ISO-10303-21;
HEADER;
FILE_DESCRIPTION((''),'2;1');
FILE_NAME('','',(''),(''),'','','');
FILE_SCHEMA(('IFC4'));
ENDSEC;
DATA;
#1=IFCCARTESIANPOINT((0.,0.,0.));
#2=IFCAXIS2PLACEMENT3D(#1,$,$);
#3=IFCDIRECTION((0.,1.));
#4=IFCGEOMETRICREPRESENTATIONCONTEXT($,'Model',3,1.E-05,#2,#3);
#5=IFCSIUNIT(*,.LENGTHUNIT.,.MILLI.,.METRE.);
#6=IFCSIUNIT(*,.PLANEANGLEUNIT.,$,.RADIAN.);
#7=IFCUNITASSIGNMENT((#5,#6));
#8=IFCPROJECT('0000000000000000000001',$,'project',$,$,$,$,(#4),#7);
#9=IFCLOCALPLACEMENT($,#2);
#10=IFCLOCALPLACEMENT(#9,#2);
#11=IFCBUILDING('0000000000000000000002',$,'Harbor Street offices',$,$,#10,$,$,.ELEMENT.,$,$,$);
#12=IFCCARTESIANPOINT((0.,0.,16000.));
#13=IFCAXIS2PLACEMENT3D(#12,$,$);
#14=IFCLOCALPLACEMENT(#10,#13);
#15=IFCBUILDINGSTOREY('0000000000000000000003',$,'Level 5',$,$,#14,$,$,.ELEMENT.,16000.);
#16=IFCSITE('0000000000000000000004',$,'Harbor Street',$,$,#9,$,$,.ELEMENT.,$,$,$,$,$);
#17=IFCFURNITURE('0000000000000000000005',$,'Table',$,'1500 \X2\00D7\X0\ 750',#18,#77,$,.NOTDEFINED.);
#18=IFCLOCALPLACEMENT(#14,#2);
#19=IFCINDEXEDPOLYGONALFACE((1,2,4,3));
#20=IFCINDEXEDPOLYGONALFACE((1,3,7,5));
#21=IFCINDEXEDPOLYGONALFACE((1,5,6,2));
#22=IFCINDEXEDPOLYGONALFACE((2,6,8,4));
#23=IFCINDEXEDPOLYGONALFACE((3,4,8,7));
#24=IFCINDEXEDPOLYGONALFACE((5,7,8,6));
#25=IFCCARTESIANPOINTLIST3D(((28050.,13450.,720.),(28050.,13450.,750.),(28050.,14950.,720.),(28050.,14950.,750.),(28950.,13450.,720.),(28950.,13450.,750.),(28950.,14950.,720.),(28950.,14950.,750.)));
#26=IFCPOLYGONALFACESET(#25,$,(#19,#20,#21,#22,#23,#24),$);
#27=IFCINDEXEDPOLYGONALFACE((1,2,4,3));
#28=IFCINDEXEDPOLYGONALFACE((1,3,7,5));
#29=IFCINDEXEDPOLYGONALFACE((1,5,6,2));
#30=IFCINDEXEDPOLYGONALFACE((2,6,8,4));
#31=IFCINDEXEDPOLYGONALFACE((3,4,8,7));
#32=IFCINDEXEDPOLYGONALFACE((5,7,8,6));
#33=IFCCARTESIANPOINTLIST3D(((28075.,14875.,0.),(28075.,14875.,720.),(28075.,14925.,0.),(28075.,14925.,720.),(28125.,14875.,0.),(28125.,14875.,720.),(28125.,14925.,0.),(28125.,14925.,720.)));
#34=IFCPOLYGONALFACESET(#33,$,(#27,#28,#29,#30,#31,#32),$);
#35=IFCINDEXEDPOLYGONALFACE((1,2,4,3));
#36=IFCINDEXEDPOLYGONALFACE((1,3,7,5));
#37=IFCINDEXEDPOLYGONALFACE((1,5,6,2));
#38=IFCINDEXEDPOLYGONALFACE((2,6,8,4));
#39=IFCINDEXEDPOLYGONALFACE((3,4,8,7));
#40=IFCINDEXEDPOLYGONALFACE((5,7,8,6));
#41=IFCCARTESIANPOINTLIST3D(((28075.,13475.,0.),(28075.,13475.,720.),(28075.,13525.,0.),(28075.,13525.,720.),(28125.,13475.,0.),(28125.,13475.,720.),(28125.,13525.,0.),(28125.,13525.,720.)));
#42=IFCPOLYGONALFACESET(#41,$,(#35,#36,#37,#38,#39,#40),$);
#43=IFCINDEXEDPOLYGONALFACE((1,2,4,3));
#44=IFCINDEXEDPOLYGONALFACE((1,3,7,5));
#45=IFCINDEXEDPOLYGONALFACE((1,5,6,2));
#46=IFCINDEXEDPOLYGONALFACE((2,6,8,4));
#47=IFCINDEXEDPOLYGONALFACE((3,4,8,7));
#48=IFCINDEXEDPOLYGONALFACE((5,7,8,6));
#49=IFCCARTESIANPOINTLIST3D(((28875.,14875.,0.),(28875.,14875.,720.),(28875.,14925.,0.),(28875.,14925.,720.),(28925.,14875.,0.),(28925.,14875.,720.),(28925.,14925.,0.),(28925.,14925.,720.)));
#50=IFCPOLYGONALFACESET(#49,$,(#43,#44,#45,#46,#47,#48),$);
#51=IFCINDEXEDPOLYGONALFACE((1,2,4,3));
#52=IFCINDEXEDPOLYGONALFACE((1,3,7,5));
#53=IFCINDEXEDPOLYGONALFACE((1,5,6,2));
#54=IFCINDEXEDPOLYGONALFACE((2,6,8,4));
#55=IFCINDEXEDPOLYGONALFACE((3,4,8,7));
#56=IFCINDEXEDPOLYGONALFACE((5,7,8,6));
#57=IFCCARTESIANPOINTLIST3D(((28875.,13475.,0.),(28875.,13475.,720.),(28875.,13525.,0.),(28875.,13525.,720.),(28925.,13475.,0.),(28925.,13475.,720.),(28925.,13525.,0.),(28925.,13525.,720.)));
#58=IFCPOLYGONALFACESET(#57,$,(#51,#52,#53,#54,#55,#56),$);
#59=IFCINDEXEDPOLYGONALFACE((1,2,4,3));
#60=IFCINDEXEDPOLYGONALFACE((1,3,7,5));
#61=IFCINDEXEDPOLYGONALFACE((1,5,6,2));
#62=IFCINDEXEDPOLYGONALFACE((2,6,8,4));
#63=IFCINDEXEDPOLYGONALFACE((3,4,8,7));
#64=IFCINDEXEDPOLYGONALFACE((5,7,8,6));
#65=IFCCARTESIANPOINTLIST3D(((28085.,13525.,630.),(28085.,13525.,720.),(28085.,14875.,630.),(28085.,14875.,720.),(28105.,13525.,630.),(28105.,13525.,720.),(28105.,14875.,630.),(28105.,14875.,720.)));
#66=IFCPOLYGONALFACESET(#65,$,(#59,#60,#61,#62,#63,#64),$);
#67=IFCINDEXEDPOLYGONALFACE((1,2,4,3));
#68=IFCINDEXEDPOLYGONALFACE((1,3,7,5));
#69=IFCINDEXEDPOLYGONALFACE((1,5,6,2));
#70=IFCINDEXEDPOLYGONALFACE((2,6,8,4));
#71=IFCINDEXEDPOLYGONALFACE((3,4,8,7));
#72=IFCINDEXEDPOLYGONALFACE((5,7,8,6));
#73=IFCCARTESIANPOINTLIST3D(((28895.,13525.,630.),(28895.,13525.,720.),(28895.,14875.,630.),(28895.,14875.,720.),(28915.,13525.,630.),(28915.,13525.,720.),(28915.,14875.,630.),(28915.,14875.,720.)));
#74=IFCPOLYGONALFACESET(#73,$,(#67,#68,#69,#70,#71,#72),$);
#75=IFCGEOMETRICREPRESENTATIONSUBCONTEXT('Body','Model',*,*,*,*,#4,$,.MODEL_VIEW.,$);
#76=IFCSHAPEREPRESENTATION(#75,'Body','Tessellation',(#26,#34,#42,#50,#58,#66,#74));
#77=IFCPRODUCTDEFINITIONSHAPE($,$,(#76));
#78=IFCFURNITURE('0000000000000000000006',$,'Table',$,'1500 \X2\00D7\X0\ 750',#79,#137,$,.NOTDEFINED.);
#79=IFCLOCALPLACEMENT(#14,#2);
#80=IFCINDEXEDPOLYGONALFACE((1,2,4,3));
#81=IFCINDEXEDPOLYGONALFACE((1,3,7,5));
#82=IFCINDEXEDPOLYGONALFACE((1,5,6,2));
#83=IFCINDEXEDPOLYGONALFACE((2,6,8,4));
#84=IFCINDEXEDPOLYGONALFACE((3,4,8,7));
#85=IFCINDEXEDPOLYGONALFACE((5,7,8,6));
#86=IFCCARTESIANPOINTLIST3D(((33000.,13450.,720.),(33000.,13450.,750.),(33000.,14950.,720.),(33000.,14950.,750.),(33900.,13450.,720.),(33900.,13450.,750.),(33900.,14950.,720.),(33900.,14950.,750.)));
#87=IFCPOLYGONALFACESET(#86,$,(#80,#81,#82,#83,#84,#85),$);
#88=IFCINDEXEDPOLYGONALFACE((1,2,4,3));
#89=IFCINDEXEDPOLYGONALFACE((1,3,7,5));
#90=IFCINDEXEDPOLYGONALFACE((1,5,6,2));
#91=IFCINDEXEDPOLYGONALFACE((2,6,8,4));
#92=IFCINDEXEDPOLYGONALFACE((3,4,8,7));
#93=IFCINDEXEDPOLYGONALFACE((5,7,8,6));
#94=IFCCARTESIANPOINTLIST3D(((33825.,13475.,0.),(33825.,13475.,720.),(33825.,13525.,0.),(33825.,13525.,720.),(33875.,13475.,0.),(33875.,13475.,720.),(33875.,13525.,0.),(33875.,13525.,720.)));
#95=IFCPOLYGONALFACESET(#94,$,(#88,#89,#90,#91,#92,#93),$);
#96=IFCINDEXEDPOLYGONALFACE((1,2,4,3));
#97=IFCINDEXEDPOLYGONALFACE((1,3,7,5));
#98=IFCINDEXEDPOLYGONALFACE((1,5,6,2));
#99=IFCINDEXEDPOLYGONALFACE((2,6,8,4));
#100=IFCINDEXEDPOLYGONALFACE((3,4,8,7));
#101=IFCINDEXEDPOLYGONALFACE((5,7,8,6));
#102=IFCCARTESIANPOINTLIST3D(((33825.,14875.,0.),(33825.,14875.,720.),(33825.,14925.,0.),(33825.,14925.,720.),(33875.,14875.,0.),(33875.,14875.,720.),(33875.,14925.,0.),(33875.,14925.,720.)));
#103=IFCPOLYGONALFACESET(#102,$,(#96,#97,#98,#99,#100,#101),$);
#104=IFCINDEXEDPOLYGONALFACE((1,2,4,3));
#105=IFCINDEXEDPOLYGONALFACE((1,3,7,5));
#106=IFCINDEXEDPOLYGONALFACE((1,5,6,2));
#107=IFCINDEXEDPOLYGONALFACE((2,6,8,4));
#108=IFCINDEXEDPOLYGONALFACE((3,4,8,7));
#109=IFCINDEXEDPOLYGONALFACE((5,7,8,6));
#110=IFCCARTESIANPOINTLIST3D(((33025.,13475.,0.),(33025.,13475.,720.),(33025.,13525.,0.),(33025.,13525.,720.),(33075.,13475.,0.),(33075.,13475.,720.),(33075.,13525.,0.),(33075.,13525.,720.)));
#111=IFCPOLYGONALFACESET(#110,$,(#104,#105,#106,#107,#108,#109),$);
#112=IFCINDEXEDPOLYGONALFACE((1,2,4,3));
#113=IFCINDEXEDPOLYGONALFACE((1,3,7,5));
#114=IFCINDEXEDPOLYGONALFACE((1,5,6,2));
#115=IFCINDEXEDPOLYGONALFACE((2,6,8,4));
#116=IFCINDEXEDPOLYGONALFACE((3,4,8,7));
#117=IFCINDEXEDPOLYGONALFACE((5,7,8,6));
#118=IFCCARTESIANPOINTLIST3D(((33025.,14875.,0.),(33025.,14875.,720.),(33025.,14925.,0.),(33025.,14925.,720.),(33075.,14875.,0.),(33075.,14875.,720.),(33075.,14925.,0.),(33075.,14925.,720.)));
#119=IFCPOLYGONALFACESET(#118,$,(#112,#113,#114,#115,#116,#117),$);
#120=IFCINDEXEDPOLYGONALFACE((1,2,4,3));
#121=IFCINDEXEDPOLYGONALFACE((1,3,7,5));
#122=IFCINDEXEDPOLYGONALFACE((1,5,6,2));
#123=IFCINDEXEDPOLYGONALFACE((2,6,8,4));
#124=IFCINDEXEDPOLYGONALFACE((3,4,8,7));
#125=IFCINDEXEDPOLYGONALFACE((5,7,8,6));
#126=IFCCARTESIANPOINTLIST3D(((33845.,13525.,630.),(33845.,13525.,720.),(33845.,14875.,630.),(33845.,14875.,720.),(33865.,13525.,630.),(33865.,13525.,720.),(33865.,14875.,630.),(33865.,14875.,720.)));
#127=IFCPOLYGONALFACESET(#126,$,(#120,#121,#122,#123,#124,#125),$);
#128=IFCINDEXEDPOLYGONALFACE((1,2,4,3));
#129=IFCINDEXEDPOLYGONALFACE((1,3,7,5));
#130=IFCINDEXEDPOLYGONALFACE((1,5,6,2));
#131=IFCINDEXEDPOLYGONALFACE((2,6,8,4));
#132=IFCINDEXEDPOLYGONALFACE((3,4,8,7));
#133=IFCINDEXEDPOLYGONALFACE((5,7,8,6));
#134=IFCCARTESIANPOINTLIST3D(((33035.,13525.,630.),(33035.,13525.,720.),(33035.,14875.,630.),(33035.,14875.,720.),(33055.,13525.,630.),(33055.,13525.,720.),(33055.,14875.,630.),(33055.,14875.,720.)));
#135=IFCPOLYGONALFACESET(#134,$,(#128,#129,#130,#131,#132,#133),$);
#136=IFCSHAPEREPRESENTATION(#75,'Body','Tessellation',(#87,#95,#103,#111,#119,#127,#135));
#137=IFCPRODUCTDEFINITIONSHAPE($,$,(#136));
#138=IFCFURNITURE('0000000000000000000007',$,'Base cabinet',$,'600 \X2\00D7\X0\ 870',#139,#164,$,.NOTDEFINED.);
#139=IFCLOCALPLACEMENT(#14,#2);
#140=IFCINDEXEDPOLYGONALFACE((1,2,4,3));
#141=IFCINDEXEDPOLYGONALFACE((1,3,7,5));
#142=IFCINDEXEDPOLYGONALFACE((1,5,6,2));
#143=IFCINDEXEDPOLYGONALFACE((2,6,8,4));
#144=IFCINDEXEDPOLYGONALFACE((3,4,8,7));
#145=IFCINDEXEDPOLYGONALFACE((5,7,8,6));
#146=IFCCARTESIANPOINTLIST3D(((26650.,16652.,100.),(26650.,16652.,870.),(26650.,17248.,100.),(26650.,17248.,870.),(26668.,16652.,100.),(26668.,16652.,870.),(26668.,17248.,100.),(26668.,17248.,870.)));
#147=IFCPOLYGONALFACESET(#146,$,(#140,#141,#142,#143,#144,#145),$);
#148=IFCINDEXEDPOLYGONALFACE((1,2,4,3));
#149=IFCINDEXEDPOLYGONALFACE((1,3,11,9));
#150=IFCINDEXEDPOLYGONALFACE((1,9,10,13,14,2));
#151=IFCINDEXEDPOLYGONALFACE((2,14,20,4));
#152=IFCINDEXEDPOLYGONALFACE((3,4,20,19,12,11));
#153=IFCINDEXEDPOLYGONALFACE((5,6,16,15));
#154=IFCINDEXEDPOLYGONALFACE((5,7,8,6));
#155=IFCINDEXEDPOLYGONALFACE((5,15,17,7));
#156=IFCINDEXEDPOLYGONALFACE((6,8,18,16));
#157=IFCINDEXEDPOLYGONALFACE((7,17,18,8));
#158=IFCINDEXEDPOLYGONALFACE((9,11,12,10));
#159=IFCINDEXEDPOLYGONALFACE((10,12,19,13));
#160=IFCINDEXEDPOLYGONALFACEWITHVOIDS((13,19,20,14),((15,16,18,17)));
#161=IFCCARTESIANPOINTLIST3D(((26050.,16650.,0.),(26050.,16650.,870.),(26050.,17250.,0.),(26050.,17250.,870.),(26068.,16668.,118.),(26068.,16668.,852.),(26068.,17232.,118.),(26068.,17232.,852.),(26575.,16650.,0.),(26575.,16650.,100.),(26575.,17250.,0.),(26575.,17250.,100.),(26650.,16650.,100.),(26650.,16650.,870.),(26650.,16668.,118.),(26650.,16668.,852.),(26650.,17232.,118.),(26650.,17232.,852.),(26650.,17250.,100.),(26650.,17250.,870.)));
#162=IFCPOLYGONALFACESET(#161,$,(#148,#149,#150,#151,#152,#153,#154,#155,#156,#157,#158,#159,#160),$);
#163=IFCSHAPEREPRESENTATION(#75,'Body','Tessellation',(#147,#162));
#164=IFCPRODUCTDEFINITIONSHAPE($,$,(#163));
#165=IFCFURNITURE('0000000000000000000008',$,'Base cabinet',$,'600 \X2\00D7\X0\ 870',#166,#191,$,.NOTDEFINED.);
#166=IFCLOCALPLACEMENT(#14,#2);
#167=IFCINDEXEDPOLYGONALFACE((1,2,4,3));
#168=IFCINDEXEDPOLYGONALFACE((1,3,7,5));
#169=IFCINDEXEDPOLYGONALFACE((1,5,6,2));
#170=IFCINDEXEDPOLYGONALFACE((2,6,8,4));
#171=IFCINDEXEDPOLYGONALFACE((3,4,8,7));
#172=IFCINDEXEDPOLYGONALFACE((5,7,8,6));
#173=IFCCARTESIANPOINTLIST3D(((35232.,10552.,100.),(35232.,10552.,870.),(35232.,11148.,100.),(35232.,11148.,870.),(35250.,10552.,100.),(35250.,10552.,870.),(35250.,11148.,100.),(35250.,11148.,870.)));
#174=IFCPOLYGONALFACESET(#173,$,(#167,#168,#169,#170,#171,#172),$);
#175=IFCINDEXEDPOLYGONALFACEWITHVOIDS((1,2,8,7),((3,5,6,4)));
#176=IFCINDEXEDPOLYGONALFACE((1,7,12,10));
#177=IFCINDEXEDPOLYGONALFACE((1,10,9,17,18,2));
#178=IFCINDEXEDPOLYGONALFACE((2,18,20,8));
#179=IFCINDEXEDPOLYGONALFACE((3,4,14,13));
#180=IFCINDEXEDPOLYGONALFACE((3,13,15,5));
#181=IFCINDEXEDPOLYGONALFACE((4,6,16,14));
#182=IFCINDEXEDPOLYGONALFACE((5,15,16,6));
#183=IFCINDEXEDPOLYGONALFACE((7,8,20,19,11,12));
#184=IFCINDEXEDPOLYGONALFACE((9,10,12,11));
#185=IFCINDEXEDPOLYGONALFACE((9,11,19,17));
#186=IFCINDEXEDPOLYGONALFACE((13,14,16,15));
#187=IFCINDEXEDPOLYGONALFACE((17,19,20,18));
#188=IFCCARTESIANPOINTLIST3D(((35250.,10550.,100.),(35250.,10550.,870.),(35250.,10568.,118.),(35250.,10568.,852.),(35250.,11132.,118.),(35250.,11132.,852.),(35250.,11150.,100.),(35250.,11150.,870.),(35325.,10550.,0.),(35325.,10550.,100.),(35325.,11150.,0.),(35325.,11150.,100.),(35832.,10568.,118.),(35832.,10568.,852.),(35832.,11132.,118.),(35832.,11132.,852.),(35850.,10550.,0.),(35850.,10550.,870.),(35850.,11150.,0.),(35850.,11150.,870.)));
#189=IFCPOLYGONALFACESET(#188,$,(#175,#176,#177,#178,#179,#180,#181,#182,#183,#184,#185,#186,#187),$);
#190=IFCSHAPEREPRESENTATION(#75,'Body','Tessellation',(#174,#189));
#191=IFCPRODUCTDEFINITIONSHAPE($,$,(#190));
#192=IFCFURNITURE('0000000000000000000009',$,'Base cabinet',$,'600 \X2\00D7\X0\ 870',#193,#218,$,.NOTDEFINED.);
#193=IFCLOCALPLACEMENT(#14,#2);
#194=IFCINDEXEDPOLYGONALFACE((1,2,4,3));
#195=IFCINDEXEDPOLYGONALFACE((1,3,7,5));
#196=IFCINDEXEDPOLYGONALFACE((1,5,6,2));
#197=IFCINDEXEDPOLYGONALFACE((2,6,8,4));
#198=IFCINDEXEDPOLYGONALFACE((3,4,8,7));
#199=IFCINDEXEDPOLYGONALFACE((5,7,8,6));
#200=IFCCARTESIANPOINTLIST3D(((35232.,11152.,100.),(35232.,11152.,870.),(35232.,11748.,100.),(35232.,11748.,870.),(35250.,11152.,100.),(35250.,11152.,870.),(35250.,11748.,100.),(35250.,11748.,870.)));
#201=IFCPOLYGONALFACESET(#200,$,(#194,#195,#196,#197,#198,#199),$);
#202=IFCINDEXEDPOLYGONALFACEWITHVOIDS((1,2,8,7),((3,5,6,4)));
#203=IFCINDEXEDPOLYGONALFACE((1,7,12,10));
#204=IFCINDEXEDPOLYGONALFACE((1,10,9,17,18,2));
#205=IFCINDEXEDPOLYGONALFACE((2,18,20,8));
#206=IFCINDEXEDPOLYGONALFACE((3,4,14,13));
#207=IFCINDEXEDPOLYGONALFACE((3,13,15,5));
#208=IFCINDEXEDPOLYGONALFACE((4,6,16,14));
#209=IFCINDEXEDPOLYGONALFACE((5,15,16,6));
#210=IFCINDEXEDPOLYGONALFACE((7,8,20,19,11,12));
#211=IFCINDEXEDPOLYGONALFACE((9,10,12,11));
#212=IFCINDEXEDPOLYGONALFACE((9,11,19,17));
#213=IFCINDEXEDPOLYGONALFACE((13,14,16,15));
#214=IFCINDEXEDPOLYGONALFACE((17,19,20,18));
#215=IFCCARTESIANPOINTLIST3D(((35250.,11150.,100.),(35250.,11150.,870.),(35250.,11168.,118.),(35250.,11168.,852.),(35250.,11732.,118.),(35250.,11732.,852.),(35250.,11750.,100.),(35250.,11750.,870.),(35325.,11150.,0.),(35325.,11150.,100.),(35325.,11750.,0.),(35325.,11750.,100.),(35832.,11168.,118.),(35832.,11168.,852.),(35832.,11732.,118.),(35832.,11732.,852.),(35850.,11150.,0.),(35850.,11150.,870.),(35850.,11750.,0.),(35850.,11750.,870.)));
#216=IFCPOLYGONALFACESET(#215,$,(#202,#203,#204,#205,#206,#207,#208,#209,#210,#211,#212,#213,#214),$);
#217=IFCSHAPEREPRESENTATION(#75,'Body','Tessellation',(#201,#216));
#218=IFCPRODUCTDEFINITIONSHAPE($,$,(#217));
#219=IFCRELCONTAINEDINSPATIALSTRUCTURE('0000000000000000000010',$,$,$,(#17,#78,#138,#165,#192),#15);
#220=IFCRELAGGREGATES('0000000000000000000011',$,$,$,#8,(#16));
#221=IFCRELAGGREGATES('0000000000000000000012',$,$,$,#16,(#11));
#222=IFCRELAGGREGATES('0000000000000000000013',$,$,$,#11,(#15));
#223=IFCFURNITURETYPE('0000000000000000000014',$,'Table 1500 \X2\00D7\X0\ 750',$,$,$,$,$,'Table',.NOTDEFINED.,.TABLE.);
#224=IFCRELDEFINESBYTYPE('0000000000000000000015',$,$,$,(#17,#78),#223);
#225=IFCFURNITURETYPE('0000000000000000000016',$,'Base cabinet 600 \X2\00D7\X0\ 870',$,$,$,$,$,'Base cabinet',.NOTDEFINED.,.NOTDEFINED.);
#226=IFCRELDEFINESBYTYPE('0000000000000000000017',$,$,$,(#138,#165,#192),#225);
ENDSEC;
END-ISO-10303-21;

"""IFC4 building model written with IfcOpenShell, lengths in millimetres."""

from ifc_helpers import new_model, entity, si_unit, direction, frame, origin, place, context, subcontext, project, spatial, polyline, outline, extrude, source, transform, mapped, type_object, type_shapes, element, save


model = new_model("IFC4")

# Units and contexts
model_context = context("Model", 3, precision=1e-05, world=origin(), true_north=direction((0.0, 1.0)))
body_context = subcontext(model_context, "Body", "Model", "MODEL_VIEW")
ifc_project = project(units=[si_unit("LENGTHUNIT", "METRE", prefix="MILLI"), si_unit("PLANEANGLEUNIT", "RADIAN")], contexts=[model_context])

# Site, building, storey
site_placement = place(None, origin())
site = spatial("IfcSite", under=ifc_project, at=site_placement, Name="Harbor Street", CompositionType="ELEMENT")
building_placement = place(site_placement, origin())
building = spatial("IfcBuilding", under=site, at=building_placement, Name="Harbor Street offices", CompositionType="ELEMENT")
storey_placement = place(building_placement, frame((0.0, 0.0, 16000.0)))
storey = spatial("IfcBuildingStorey", under=building, at=storey_placement, Name="Level 5", CompositionType="ELEMENT", Elevation=16000.0)

# Furniture
furniture_type_1 = type_object("IfcFurnitureType", Name="Table 1500 × 750", ElementType="Table", AssemblyPlace="NOTDEFINED", PredefinedType="TABLE")
shared_shape_1 = source(origin(), body_context, "Body", "SweptSolid", [
    extrude(outline(polyline([(-750.0, -450.0), (750.0, -450.0), (750.0, 450.0), (-750.0, 450.0), (-750.0, -450.0)])), frame((0.0, 0.0, 720.0)), (0.0, 0.0, 1.0), 30.0),
    extrude(outline(polyline([(-725.0, -425.0), (-675.0, -425.0), (-675.0, -375.0), (-725.0, -375.0), (-725.0, -425.0)])), origin(), (0.0, 0.0, 1.0), 720.0),
    extrude(outline(polyline([(675.0, -425.0), (725.0, -425.0), (725.0, -375.0), (675.0, -375.0), (675.0, -425.0)])), origin(), (0.0, 0.0, 1.0), 720.0),
    extrude(outline(polyline([(-725.0, 375.0), (-675.0, 375.0), (-675.0, 425.0), (-725.0, 425.0), (-725.0, 375.0)])), origin(), (0.0, 0.0, 1.0), 720.0),
    extrude(outline(polyline([(675.0, 375.0), (725.0, 375.0), (725.0, 425.0), (675.0, 425.0), (675.0, 375.0)])), origin(), (0.0, 0.0, 1.0), 720.0),
    extrude(outline(polyline([(-675.0, -415.0), (675.0, -415.0), (675.0, -395.0), (-675.0, -395.0), (-675.0, -415.0)])), frame((0.0, 0.0, 630.0)), (0.0, 0.0, 1.0), 90.0),
    extrude(outline(polyline([(-675.0, 395.0), (675.0, 395.0), (675.0, 415.0), (-675.0, 415.0), (-675.0, 395.0)])), frame((0.0, 0.0, 630.0)), (0.0, 0.0, 1.0), 90.0),
])
type_shapes(furniture_type_1, [shared_shape_1])
for number, where, z_axis, x_axis, name in (
    (1, (28500.0, 14200.0, 0.0), (0.0, 0.0, 1.0), (0.0, -1.0, 0.0), "Table"),
    (2, (33450.0, 14200.0, 0.0), (0.0, 0.0, 1.0), (0.0, 1.0, 0.0), "Table"),
):
    element("IfcFurniture", number, at=place(storey_placement, frame(where, z_axis=z_axis, x_axis=x_axis)), inside=storey, type_object=furniture_type_1, Name=name, ObjectType="1500 × 750", PredefinedType="NOTDEFINED", context=body_context, shape_type="MappedRepresentation", body=[
        mapped(shared_shape_1, transform((0.0, 0.0, 0.0))),
    ])
furniture_type_2 = type_object("IfcFurnitureType", Name="Base cabinet 600 × 870", ElementType="Base cabinet", AssemblyPlace="NOTDEFINED", PredefinedType="NOTDEFINED")
cartesian_point_1 = entity("IfcCartesianPoint", [-300.0, 0.0])
cartesian_point_2 = entity("IfcCartesianPoint", [-282.0, -1.0])
cartesian_point_3 = entity("IfcCartesianPoint", [-301.0, -1.0])
shared_shape_2 = source(origin(), body_context, "Body", "SolidModel", [
    extrude(outline(polyline([(-298.0, -18.0), (298.0, -18.0), (298.0, 0.0), (-298.0, 0.0), (-298.0, -18.0)])), frame((0.0, 0.0, 100.0)), (0.0, 0.0, 1.0), 770.0),
    entity("IfcCsgSolid", entity("IfcBooleanResult", "DIFFERENCE", entity("IfcBooleanResult", "DIFFERENCE", entity("IfcExtrudedAreaSolid", entity("IfcArbitraryClosedProfileDef", "AREA", None, entity("IfcPolyline", [cartesian_point_1, entity("IfcCartesianPoint", [300.0, 0.0]), entity("IfcCartesianPoint", [300.0, 600.0]), entity("IfcCartesianPoint", [-300.0, 600.0]), cartesian_point_1])), entity("IfcAxis2Placement3D", entity("IfcCartesianPoint", [0.0, 0.0, 0.0])), entity("IfcDirection", [0.0, 0.0, 1.0]), 870.0), entity("IfcExtrudedAreaSolid", entity("IfcArbitraryClosedProfileDef", "AREA", None, entity("IfcPolyline", [cartesian_point_2, entity("IfcCartesianPoint", [282.0, -1.0]), entity("IfcCartesianPoint", [282.0, 582.0]), entity("IfcCartesianPoint", [-282.0, 582.0]), cartesian_point_2])), entity("IfcAxis2Placement3D", entity("IfcCartesianPoint", [0.0, 0.0, 118.0])), entity("IfcDirection", [0.0, 0.0, 1.0]), 734.0)), entity("IfcExtrudedAreaSolid", entity("IfcArbitraryClosedProfileDef", "AREA", None, entity("IfcPolyline", [cartesian_point_3, entity("IfcCartesianPoint", [301.0, -1.0]), entity("IfcCartesianPoint", [301.0, 75.0]), entity("IfcCartesianPoint", [-301.0, 75.0]), cartesian_point_3])), entity("IfcAxis2Placement3D", entity("IfcCartesianPoint", [0.0, 0.0, -1.0])), entity("IfcDirection", [0.0, 0.0, 1.0]), 101.0))),
])
type_shapes(furniture_type_2, [shared_shape_2])
for number, where, z_axis, x_axis, name in (
    (3, (26650.0, 16950.0, 0.0), (0.0, 0.0, 1.0), (0.0, 1.0, 0.0), "Base cabinet"),
    (4, (35250.0, 10850.0, 0.0), (0.0, 0.0, 1.0), (0.0, -1.0, 0.0), "Base cabinet"),
    (5, (35250.0, 11450.0, 0.0), (0.0, 0.0, 1.0), (0.0, -1.0, 0.0), "Base cabinet"),
):
    element("IfcFurniture", number, at=place(storey_placement, frame(where, z_axis=z_axis, x_axis=x_axis)), inside=storey, type_object=furniture_type_2, Name=name, ObjectType="600 × 870", PredefinedType="NOTDEFINED", context=body_context, shape_type="MappedRepresentation", body=[
        mapped(shared_shape_2, transform((0.0, 0.0, 0.0))),
    ])

save(model, "model.ifc")
